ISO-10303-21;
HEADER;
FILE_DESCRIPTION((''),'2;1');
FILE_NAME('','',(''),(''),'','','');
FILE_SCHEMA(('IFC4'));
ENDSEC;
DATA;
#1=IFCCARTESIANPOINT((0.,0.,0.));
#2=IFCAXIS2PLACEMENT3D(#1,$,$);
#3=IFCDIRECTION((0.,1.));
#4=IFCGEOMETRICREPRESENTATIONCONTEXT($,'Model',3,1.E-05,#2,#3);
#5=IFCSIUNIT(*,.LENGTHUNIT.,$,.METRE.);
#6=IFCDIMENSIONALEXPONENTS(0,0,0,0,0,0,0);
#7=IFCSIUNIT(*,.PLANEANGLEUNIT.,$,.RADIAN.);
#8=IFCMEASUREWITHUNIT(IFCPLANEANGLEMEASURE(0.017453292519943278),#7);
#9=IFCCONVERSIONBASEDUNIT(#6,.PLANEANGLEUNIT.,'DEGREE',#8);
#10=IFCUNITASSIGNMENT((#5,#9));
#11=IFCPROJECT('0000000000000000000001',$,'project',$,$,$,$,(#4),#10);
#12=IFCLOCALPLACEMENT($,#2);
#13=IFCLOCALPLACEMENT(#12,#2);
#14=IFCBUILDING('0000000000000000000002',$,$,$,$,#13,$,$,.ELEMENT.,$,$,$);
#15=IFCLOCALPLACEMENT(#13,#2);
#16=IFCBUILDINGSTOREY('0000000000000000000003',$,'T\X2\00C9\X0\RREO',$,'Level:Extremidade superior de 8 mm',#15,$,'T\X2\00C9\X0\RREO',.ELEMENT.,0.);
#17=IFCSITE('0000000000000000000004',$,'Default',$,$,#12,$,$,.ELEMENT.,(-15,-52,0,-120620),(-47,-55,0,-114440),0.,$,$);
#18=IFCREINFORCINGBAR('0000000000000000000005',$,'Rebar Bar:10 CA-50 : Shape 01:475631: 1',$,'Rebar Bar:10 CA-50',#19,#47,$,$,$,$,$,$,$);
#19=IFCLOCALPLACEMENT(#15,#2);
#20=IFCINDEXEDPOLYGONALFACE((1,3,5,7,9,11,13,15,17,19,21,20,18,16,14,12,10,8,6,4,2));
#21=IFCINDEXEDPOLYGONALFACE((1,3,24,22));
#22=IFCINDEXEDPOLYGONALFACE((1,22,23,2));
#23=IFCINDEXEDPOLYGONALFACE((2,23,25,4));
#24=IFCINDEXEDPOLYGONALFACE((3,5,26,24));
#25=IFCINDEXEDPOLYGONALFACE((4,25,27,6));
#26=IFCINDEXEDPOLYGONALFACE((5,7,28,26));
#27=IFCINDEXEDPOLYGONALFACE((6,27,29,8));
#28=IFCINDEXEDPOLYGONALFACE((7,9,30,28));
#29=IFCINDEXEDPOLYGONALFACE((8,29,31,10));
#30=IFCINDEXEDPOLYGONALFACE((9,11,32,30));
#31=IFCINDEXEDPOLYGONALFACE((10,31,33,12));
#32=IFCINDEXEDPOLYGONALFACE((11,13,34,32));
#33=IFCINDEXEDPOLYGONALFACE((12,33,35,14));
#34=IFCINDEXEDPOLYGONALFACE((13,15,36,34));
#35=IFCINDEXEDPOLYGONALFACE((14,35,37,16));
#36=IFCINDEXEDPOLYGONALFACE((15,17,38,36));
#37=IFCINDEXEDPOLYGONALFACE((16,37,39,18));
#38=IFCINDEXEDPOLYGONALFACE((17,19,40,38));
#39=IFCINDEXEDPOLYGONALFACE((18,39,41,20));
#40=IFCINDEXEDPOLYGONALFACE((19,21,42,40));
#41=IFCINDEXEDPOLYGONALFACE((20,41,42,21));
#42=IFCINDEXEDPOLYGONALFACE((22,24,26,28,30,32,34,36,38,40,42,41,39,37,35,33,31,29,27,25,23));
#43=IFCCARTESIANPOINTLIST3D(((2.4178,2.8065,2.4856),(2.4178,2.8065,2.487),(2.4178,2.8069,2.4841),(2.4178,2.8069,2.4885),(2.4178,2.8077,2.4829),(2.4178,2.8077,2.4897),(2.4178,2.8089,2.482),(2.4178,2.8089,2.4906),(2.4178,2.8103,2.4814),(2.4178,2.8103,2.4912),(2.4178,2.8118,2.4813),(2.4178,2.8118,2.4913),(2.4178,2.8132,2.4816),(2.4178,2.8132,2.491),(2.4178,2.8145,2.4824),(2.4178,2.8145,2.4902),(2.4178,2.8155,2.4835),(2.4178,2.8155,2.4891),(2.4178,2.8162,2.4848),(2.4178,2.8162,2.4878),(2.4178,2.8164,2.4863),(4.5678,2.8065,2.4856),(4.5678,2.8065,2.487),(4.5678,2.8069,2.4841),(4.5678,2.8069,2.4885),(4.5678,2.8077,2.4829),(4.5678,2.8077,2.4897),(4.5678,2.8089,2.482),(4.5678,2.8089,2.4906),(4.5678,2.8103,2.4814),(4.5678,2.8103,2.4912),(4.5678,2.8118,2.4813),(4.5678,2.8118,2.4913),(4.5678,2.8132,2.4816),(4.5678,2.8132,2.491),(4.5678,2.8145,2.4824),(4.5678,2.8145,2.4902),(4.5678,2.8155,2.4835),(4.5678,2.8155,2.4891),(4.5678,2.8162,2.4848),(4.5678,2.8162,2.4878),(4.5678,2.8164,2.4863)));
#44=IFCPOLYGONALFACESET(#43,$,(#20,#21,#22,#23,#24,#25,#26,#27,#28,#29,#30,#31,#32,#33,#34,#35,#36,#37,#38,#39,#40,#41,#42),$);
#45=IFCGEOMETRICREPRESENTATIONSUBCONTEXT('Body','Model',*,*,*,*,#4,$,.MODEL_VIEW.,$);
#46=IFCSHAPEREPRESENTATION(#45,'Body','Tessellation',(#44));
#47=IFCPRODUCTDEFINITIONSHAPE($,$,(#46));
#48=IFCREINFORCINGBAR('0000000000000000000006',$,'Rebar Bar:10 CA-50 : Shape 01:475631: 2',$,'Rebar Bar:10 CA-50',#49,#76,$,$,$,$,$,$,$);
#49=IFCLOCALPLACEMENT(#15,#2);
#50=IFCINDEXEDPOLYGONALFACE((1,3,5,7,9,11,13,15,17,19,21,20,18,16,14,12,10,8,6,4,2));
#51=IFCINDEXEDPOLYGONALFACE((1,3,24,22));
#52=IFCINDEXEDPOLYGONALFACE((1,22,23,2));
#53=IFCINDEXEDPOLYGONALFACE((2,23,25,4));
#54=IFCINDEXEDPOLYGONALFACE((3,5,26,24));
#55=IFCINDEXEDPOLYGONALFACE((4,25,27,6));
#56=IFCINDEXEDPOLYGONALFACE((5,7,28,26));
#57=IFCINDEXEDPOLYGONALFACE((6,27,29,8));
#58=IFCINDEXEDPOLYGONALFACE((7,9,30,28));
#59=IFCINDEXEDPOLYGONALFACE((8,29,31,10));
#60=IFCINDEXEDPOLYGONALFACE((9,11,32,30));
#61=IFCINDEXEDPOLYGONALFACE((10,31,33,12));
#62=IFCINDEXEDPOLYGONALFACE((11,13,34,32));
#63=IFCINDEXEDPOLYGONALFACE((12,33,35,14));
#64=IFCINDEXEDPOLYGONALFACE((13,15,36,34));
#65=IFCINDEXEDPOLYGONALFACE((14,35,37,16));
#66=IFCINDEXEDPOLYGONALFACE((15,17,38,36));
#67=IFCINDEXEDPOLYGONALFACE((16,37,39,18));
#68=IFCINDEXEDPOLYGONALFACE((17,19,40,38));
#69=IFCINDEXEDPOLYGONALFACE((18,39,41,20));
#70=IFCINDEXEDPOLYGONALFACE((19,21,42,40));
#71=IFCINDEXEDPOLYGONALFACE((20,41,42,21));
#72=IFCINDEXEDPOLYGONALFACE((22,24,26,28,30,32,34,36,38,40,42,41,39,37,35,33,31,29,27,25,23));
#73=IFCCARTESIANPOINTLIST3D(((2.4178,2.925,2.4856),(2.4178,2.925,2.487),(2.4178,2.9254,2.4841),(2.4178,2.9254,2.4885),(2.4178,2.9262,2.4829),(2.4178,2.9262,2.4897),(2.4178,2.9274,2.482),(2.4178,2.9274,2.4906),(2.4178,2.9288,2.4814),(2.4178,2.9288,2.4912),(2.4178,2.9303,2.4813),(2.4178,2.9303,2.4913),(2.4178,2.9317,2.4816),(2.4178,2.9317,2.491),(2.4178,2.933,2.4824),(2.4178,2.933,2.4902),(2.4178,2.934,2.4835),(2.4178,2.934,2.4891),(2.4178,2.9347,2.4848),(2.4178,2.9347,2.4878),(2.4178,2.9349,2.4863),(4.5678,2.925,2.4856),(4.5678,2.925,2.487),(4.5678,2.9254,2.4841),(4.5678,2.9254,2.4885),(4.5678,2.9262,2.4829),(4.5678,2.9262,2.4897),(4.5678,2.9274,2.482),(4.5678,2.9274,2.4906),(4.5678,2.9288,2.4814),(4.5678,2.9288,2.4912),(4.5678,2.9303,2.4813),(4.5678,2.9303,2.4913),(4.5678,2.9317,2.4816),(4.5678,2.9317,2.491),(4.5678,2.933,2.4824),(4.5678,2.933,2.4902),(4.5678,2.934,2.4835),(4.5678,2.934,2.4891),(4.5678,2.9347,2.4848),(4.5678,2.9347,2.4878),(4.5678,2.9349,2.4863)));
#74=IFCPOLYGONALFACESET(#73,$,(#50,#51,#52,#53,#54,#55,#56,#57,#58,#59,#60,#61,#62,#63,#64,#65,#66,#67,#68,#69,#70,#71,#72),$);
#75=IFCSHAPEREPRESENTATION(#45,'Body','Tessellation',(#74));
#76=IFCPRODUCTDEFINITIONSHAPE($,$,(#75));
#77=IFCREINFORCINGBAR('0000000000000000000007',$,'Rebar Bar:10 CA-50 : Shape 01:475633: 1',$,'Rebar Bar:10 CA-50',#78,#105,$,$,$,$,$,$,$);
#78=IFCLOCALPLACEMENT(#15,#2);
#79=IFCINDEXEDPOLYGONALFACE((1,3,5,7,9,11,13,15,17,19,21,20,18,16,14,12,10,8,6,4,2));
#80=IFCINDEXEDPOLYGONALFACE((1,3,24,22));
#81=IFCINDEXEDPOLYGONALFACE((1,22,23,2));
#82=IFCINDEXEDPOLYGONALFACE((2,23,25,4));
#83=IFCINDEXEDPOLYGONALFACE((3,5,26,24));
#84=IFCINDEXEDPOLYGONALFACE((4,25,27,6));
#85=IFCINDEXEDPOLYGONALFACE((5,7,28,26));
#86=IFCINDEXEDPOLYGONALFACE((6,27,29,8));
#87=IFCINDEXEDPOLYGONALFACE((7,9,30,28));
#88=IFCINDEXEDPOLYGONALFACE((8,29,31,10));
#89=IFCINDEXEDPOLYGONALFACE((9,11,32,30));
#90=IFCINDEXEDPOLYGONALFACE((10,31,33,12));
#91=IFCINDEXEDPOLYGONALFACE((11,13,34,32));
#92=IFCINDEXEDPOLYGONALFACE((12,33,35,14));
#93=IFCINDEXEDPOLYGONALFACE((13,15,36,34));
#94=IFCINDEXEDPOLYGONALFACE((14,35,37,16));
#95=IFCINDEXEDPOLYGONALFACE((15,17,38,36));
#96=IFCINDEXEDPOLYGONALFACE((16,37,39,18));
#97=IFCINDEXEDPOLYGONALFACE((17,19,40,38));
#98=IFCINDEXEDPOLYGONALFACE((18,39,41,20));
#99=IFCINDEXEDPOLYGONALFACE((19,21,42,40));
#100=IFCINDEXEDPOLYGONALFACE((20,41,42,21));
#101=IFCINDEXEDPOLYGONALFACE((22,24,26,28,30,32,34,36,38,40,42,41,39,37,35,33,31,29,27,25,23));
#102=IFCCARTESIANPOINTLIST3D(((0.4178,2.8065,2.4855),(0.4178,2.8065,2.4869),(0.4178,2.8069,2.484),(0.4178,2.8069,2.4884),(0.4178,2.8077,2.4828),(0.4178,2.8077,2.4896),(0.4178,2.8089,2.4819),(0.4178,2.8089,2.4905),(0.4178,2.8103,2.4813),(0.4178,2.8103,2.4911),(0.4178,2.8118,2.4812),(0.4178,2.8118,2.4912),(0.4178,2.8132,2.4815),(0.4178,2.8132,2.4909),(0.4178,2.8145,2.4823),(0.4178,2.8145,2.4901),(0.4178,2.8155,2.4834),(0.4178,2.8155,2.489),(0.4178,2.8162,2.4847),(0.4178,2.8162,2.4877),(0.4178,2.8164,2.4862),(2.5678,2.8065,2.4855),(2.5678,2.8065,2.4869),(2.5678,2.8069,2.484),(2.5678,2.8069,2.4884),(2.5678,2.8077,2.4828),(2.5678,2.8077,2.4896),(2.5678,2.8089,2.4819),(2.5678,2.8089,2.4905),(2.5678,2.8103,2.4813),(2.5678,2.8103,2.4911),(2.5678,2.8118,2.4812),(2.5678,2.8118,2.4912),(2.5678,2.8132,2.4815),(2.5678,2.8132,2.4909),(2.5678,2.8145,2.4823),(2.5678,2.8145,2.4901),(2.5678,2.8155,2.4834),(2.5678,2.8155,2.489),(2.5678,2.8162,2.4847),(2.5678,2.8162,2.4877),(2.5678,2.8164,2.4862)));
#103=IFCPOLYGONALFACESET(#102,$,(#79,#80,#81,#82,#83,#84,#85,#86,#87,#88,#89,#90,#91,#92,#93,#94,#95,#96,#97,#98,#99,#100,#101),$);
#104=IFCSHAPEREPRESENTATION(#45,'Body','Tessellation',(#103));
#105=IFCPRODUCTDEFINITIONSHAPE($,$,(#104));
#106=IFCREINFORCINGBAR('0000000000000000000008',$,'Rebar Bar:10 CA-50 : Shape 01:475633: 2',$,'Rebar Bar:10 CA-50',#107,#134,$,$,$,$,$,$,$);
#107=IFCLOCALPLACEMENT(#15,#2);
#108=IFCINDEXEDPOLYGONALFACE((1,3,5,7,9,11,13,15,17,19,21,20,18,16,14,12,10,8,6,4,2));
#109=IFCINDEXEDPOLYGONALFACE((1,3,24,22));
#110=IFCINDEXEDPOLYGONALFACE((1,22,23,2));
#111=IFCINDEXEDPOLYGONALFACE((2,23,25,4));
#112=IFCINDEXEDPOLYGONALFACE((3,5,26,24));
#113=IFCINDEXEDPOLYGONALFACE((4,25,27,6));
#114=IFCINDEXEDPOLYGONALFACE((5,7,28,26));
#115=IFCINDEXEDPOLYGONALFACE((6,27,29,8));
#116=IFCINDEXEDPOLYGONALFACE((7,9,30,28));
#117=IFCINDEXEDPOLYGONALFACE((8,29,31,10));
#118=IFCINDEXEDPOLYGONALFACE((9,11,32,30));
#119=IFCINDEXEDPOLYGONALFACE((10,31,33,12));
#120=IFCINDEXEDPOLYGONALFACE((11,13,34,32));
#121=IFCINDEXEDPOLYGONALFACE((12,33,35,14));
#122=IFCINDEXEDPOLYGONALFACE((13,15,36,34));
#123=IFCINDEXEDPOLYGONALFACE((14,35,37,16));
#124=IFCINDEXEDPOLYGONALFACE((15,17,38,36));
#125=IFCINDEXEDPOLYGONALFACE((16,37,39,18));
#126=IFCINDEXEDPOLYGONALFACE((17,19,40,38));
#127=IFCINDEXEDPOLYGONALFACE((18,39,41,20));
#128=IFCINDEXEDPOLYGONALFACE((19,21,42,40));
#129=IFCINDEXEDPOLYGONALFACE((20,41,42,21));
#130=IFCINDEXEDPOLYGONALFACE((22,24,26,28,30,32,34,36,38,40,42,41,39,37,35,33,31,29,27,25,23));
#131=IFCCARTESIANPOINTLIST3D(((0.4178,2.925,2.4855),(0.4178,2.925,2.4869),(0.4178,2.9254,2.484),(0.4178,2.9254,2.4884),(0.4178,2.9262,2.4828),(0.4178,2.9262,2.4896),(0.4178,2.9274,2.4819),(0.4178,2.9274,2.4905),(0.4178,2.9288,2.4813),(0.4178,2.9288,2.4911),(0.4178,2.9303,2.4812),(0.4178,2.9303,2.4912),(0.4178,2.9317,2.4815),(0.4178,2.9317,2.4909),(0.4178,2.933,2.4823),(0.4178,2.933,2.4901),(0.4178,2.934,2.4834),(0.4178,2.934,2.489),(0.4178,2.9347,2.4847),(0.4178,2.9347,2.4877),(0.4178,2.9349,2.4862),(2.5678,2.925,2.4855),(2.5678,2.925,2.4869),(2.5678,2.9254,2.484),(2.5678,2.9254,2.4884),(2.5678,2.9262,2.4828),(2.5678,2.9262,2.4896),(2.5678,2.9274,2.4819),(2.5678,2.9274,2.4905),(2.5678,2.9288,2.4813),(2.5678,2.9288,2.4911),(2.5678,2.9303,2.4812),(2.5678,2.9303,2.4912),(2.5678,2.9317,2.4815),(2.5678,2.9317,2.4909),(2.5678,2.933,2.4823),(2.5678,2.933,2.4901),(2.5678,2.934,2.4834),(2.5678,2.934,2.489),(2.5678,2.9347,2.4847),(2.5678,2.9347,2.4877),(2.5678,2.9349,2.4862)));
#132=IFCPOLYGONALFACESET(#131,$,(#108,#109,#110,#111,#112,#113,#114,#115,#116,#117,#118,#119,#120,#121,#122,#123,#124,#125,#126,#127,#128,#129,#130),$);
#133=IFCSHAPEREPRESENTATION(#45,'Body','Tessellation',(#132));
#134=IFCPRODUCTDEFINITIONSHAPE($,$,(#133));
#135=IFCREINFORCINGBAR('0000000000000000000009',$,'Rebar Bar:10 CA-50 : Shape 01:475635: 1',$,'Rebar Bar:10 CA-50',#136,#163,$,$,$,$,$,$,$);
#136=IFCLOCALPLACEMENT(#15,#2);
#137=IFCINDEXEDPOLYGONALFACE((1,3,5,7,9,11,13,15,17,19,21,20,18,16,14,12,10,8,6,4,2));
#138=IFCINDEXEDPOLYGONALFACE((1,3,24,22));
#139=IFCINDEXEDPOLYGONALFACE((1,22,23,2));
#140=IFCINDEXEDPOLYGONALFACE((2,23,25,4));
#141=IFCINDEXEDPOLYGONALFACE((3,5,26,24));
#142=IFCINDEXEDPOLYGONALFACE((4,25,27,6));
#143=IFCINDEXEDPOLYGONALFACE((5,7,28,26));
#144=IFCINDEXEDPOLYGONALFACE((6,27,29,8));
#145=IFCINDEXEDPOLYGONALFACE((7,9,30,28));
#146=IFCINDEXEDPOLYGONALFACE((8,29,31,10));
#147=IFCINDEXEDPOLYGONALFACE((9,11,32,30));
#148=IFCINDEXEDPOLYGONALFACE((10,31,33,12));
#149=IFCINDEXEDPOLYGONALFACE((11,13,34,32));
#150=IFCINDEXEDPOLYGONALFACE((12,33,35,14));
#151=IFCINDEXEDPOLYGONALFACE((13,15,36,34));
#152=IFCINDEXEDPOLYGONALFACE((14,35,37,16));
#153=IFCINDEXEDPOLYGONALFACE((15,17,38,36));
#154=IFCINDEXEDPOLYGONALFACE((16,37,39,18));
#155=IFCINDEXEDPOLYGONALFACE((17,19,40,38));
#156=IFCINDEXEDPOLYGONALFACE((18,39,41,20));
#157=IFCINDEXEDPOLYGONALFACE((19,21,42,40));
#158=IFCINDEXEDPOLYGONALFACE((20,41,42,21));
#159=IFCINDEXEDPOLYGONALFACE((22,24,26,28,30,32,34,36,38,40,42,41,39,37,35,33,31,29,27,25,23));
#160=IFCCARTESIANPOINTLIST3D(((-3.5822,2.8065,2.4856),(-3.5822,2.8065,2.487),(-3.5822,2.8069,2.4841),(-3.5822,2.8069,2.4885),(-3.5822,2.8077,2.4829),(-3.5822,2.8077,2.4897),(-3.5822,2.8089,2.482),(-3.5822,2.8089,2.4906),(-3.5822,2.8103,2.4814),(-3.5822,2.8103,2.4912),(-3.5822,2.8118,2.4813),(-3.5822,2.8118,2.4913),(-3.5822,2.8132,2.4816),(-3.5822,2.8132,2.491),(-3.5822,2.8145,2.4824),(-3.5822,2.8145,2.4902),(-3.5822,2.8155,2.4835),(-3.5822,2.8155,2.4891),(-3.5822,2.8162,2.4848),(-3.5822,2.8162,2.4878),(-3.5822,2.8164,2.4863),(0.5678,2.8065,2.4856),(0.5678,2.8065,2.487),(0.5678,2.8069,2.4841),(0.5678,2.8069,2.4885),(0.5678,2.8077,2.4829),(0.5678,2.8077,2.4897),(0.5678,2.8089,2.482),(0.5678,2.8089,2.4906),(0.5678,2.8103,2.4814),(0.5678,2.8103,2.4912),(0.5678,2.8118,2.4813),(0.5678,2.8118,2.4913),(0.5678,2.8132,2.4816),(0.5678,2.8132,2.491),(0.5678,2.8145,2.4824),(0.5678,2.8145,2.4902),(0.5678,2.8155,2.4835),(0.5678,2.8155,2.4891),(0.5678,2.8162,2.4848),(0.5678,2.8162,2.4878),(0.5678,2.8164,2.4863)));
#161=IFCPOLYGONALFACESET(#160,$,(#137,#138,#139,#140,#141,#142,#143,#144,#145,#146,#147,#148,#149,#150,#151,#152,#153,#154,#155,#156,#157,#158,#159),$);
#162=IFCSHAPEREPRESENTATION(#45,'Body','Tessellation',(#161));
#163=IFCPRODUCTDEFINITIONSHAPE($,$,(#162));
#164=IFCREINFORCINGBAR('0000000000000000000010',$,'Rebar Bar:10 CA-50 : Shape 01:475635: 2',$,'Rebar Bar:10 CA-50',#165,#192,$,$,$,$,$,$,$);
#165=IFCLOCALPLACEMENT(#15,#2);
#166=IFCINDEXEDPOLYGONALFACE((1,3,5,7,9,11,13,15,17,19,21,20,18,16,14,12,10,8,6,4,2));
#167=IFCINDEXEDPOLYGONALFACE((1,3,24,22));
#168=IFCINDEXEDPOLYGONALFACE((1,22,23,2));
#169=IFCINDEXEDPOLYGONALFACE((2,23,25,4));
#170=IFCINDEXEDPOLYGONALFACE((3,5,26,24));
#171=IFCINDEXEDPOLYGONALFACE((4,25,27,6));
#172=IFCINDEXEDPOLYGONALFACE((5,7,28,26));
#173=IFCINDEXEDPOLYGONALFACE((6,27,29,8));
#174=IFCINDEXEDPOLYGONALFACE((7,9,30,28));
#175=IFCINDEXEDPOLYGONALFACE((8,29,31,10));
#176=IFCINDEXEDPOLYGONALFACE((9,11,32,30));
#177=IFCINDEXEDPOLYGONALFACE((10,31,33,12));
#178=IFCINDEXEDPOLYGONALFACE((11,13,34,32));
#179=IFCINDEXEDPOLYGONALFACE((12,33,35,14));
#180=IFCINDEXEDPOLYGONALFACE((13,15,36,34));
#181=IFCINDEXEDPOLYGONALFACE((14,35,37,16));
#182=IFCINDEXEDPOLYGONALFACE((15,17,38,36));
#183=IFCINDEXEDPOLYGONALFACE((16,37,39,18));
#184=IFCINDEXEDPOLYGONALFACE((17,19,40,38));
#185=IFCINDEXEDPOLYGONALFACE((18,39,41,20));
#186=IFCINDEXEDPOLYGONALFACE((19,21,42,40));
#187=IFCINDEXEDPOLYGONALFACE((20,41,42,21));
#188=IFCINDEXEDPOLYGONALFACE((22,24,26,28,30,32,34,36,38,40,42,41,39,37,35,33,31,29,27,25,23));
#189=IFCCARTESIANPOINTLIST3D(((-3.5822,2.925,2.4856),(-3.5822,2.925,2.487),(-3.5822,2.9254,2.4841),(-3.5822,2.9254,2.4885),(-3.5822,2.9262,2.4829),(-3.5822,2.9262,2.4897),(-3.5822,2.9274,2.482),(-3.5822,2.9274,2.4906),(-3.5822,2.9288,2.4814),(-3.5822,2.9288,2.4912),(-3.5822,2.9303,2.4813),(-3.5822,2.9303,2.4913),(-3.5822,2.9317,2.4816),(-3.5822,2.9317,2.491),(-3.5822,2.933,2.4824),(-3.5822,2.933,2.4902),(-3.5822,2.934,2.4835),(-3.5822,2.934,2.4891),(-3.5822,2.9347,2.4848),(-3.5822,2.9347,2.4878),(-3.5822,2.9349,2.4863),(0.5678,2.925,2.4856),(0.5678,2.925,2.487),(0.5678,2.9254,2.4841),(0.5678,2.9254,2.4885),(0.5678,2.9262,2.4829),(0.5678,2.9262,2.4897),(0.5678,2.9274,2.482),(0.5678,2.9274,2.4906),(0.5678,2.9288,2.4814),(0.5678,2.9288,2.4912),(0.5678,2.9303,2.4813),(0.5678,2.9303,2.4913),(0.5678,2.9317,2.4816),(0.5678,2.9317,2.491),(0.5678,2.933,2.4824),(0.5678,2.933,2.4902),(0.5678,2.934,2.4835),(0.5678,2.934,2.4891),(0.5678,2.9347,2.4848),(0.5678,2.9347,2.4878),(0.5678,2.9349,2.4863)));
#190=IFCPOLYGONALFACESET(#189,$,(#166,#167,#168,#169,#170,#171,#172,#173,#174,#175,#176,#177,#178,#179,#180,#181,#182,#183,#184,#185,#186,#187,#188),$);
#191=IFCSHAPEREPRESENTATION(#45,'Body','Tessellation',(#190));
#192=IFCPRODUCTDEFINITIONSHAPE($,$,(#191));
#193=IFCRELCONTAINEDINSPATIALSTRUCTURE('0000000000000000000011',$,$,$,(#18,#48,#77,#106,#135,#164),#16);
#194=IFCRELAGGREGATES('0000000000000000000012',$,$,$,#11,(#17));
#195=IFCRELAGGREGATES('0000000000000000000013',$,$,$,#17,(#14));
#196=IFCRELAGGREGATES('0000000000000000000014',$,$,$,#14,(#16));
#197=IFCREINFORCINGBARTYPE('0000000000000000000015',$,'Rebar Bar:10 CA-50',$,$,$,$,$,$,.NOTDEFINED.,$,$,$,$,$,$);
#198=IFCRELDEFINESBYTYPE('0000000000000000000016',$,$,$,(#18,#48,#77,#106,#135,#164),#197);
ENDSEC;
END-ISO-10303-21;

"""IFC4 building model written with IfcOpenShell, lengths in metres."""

from ifc_helpers import new_model, entity, si_unit, converted_unit, direction, origin, place, context, subcontext, project, spatial, type_object, element, save


model = new_model("IFC4")

# Units and contexts
model_context = context("Model", 3, precision=1e-05, world=origin(), true_north=direction((0.0, 1.0)))
body_context = subcontext(model_context, "Body", "Model", "MODEL_VIEW")
ifc_project = project(units=[si_unit("LENGTHUNIT", "METRE"), converted_unit("PLANEANGLEUNIT", "DEGREE", entity("IfcPlaneAngleMeasure", 0.017453292519943278), si_unit("PLANEANGLEUNIT", "RADIAN"), dimensions=[0, 0, 0, 0, 0, 0, 0])], contexts=[model_context])

# Site, building, storey
site_placement = place(None, origin())
site = spatial("IfcSite", under=ifc_project, at=site_placement, Name="Default", CompositionType="ELEMENT", RefLatitude=(-15, -52, 0, -120620), RefLongitude=(-47, -55, 0, -114440), RefElevation=0.0)
building_placement = place(site_placement, origin())
building = spatial("IfcBuilding", under=site, at=building_placement, CompositionType="ELEMENT")
storey_placement = place(building_placement, origin())
storey = spatial("IfcBuildingStorey", under=building, at=storey_placement, Name="TÉRREO", ObjectType="Level:Extremidade superior de 8 mm", LongName="TÉRREO", CompositionType="ELEMENT", Elevation=0.0)

# Reinforcing bars
reinforcing_bar_type_1 = type_object("IfcReinforcingBarType", Name="Rebar Bar:10 CA-50", PredefinedType="NOTDEFINED")
reinforcing_bar_1_placement = place(storey_placement, origin())
element("IfcReinforcingBar", 1, at=reinforcing_bar_1_placement, inside=storey, type_object=reinforcing_bar_type_1, Name="Rebar Bar:10 CA-50 : Shape 01:475631: 1", ObjectType="Rebar Bar:10 CA-50", context=body_context, shape_type="AdvancedSweptSolid", body=[
    entity("IfcSweptDiskSolid", entity("IfcIndexedPolyCurve", entity("IfcCartesianPointList3D", [[2.4178, 2.8114, 2.4863], [4.5678, 2.8114, 2.4863]]), None, False), 0.005, None, 0.0, 1.0),
])
reinforcing_bar_2_placement = place(storey_placement, origin())
element("IfcReinforcingBar", 2, at=reinforcing_bar_2_placement, inside=storey, type_object=reinforcing_bar_type_1, Name="Rebar Bar:10 CA-50 : Shape 01:475631: 2", ObjectType="Rebar Bar:10 CA-50", context=body_context, shape_type="AdvancedSweptSolid", body=[
    entity("IfcSweptDiskSolid", entity("IfcIndexedPolyCurve", entity("IfcCartesianPointList3D", [[2.4178, 2.9299, 2.4863], [4.5678, 2.9299, 2.4863]]), None, False), 0.005, None, 0.0, 1.0),
])
reinforcing_bar_3_placement = place(storey_placement, origin())
element("IfcReinforcingBar", 3, at=reinforcing_bar_3_placement, inside=storey, type_object=reinforcing_bar_type_1, Name="Rebar Bar:10 CA-50 : Shape 01:475633: 1", ObjectType="Rebar Bar:10 CA-50", context=body_context, shape_type="AdvancedSweptSolid", body=[
    entity("IfcSweptDiskSolid", entity("IfcIndexedPolyCurve", entity("IfcCartesianPointList3D", [[0.4178, 2.8114, 2.4862], [2.5678, 2.8114, 2.4862]]), None, False), 0.005, None, 0.0, 1.0),
])
reinforcing_bar_4_placement = place(storey_placement, origin())
element("IfcReinforcingBar", 4, at=reinforcing_bar_4_placement, inside=storey, type_object=reinforcing_bar_type_1, Name="Rebar Bar:10 CA-50 : Shape 01:475633: 2", ObjectType="Rebar Bar:10 CA-50", context=body_context, shape_type="AdvancedSweptSolid", body=[
    entity("IfcSweptDiskSolid", entity("IfcIndexedPolyCurve", entity("IfcCartesianPointList3D", [[0.4178, 2.9299, 2.4862], [2.5678, 2.9299, 2.4862]]), None, False), 0.005, None, 0.0, 1.0),
])
reinforcing_bar_5_placement = place(storey_placement, origin())
element("IfcReinforcingBar", 5, at=reinforcing_bar_5_placement, inside=storey, type_object=reinforcing_bar_type_1, Name="Rebar Bar:10 CA-50 : Shape 01:475635: 1", ObjectType="Rebar Bar:10 CA-50", context=body_context, shape_type="AdvancedSweptSolid", body=[
    entity("IfcSweptDiskSolid", entity("IfcIndexedPolyCurve", entity("IfcCartesianPointList3D", [[-3.5822, 2.8114, 2.4863], [0.5678, 2.8114, 2.4863]]), None, False), 0.005, None, 0.0, 1.0),
])
reinforcing_bar_6_placement = place(storey_placement, origin())
element("IfcReinforcingBar", 6, at=reinforcing_bar_6_placement, inside=storey, type_object=reinforcing_bar_type_1, Name="Rebar Bar:10 CA-50 : Shape 01:475635: 2", ObjectType="Rebar Bar:10 CA-50", context=body_context, shape_type="AdvancedSweptSolid", body=[
    entity("IfcSweptDiskSolid", entity("IfcIndexedPolyCurve", entity("IfcCartesianPointList3D", [[-3.5822, 2.9299, 2.4863], [0.5678, 2.9299, 2.4863]]), None, False), 0.005, None, 0.0, 1.0),
])

save(model, "model.ifc")
